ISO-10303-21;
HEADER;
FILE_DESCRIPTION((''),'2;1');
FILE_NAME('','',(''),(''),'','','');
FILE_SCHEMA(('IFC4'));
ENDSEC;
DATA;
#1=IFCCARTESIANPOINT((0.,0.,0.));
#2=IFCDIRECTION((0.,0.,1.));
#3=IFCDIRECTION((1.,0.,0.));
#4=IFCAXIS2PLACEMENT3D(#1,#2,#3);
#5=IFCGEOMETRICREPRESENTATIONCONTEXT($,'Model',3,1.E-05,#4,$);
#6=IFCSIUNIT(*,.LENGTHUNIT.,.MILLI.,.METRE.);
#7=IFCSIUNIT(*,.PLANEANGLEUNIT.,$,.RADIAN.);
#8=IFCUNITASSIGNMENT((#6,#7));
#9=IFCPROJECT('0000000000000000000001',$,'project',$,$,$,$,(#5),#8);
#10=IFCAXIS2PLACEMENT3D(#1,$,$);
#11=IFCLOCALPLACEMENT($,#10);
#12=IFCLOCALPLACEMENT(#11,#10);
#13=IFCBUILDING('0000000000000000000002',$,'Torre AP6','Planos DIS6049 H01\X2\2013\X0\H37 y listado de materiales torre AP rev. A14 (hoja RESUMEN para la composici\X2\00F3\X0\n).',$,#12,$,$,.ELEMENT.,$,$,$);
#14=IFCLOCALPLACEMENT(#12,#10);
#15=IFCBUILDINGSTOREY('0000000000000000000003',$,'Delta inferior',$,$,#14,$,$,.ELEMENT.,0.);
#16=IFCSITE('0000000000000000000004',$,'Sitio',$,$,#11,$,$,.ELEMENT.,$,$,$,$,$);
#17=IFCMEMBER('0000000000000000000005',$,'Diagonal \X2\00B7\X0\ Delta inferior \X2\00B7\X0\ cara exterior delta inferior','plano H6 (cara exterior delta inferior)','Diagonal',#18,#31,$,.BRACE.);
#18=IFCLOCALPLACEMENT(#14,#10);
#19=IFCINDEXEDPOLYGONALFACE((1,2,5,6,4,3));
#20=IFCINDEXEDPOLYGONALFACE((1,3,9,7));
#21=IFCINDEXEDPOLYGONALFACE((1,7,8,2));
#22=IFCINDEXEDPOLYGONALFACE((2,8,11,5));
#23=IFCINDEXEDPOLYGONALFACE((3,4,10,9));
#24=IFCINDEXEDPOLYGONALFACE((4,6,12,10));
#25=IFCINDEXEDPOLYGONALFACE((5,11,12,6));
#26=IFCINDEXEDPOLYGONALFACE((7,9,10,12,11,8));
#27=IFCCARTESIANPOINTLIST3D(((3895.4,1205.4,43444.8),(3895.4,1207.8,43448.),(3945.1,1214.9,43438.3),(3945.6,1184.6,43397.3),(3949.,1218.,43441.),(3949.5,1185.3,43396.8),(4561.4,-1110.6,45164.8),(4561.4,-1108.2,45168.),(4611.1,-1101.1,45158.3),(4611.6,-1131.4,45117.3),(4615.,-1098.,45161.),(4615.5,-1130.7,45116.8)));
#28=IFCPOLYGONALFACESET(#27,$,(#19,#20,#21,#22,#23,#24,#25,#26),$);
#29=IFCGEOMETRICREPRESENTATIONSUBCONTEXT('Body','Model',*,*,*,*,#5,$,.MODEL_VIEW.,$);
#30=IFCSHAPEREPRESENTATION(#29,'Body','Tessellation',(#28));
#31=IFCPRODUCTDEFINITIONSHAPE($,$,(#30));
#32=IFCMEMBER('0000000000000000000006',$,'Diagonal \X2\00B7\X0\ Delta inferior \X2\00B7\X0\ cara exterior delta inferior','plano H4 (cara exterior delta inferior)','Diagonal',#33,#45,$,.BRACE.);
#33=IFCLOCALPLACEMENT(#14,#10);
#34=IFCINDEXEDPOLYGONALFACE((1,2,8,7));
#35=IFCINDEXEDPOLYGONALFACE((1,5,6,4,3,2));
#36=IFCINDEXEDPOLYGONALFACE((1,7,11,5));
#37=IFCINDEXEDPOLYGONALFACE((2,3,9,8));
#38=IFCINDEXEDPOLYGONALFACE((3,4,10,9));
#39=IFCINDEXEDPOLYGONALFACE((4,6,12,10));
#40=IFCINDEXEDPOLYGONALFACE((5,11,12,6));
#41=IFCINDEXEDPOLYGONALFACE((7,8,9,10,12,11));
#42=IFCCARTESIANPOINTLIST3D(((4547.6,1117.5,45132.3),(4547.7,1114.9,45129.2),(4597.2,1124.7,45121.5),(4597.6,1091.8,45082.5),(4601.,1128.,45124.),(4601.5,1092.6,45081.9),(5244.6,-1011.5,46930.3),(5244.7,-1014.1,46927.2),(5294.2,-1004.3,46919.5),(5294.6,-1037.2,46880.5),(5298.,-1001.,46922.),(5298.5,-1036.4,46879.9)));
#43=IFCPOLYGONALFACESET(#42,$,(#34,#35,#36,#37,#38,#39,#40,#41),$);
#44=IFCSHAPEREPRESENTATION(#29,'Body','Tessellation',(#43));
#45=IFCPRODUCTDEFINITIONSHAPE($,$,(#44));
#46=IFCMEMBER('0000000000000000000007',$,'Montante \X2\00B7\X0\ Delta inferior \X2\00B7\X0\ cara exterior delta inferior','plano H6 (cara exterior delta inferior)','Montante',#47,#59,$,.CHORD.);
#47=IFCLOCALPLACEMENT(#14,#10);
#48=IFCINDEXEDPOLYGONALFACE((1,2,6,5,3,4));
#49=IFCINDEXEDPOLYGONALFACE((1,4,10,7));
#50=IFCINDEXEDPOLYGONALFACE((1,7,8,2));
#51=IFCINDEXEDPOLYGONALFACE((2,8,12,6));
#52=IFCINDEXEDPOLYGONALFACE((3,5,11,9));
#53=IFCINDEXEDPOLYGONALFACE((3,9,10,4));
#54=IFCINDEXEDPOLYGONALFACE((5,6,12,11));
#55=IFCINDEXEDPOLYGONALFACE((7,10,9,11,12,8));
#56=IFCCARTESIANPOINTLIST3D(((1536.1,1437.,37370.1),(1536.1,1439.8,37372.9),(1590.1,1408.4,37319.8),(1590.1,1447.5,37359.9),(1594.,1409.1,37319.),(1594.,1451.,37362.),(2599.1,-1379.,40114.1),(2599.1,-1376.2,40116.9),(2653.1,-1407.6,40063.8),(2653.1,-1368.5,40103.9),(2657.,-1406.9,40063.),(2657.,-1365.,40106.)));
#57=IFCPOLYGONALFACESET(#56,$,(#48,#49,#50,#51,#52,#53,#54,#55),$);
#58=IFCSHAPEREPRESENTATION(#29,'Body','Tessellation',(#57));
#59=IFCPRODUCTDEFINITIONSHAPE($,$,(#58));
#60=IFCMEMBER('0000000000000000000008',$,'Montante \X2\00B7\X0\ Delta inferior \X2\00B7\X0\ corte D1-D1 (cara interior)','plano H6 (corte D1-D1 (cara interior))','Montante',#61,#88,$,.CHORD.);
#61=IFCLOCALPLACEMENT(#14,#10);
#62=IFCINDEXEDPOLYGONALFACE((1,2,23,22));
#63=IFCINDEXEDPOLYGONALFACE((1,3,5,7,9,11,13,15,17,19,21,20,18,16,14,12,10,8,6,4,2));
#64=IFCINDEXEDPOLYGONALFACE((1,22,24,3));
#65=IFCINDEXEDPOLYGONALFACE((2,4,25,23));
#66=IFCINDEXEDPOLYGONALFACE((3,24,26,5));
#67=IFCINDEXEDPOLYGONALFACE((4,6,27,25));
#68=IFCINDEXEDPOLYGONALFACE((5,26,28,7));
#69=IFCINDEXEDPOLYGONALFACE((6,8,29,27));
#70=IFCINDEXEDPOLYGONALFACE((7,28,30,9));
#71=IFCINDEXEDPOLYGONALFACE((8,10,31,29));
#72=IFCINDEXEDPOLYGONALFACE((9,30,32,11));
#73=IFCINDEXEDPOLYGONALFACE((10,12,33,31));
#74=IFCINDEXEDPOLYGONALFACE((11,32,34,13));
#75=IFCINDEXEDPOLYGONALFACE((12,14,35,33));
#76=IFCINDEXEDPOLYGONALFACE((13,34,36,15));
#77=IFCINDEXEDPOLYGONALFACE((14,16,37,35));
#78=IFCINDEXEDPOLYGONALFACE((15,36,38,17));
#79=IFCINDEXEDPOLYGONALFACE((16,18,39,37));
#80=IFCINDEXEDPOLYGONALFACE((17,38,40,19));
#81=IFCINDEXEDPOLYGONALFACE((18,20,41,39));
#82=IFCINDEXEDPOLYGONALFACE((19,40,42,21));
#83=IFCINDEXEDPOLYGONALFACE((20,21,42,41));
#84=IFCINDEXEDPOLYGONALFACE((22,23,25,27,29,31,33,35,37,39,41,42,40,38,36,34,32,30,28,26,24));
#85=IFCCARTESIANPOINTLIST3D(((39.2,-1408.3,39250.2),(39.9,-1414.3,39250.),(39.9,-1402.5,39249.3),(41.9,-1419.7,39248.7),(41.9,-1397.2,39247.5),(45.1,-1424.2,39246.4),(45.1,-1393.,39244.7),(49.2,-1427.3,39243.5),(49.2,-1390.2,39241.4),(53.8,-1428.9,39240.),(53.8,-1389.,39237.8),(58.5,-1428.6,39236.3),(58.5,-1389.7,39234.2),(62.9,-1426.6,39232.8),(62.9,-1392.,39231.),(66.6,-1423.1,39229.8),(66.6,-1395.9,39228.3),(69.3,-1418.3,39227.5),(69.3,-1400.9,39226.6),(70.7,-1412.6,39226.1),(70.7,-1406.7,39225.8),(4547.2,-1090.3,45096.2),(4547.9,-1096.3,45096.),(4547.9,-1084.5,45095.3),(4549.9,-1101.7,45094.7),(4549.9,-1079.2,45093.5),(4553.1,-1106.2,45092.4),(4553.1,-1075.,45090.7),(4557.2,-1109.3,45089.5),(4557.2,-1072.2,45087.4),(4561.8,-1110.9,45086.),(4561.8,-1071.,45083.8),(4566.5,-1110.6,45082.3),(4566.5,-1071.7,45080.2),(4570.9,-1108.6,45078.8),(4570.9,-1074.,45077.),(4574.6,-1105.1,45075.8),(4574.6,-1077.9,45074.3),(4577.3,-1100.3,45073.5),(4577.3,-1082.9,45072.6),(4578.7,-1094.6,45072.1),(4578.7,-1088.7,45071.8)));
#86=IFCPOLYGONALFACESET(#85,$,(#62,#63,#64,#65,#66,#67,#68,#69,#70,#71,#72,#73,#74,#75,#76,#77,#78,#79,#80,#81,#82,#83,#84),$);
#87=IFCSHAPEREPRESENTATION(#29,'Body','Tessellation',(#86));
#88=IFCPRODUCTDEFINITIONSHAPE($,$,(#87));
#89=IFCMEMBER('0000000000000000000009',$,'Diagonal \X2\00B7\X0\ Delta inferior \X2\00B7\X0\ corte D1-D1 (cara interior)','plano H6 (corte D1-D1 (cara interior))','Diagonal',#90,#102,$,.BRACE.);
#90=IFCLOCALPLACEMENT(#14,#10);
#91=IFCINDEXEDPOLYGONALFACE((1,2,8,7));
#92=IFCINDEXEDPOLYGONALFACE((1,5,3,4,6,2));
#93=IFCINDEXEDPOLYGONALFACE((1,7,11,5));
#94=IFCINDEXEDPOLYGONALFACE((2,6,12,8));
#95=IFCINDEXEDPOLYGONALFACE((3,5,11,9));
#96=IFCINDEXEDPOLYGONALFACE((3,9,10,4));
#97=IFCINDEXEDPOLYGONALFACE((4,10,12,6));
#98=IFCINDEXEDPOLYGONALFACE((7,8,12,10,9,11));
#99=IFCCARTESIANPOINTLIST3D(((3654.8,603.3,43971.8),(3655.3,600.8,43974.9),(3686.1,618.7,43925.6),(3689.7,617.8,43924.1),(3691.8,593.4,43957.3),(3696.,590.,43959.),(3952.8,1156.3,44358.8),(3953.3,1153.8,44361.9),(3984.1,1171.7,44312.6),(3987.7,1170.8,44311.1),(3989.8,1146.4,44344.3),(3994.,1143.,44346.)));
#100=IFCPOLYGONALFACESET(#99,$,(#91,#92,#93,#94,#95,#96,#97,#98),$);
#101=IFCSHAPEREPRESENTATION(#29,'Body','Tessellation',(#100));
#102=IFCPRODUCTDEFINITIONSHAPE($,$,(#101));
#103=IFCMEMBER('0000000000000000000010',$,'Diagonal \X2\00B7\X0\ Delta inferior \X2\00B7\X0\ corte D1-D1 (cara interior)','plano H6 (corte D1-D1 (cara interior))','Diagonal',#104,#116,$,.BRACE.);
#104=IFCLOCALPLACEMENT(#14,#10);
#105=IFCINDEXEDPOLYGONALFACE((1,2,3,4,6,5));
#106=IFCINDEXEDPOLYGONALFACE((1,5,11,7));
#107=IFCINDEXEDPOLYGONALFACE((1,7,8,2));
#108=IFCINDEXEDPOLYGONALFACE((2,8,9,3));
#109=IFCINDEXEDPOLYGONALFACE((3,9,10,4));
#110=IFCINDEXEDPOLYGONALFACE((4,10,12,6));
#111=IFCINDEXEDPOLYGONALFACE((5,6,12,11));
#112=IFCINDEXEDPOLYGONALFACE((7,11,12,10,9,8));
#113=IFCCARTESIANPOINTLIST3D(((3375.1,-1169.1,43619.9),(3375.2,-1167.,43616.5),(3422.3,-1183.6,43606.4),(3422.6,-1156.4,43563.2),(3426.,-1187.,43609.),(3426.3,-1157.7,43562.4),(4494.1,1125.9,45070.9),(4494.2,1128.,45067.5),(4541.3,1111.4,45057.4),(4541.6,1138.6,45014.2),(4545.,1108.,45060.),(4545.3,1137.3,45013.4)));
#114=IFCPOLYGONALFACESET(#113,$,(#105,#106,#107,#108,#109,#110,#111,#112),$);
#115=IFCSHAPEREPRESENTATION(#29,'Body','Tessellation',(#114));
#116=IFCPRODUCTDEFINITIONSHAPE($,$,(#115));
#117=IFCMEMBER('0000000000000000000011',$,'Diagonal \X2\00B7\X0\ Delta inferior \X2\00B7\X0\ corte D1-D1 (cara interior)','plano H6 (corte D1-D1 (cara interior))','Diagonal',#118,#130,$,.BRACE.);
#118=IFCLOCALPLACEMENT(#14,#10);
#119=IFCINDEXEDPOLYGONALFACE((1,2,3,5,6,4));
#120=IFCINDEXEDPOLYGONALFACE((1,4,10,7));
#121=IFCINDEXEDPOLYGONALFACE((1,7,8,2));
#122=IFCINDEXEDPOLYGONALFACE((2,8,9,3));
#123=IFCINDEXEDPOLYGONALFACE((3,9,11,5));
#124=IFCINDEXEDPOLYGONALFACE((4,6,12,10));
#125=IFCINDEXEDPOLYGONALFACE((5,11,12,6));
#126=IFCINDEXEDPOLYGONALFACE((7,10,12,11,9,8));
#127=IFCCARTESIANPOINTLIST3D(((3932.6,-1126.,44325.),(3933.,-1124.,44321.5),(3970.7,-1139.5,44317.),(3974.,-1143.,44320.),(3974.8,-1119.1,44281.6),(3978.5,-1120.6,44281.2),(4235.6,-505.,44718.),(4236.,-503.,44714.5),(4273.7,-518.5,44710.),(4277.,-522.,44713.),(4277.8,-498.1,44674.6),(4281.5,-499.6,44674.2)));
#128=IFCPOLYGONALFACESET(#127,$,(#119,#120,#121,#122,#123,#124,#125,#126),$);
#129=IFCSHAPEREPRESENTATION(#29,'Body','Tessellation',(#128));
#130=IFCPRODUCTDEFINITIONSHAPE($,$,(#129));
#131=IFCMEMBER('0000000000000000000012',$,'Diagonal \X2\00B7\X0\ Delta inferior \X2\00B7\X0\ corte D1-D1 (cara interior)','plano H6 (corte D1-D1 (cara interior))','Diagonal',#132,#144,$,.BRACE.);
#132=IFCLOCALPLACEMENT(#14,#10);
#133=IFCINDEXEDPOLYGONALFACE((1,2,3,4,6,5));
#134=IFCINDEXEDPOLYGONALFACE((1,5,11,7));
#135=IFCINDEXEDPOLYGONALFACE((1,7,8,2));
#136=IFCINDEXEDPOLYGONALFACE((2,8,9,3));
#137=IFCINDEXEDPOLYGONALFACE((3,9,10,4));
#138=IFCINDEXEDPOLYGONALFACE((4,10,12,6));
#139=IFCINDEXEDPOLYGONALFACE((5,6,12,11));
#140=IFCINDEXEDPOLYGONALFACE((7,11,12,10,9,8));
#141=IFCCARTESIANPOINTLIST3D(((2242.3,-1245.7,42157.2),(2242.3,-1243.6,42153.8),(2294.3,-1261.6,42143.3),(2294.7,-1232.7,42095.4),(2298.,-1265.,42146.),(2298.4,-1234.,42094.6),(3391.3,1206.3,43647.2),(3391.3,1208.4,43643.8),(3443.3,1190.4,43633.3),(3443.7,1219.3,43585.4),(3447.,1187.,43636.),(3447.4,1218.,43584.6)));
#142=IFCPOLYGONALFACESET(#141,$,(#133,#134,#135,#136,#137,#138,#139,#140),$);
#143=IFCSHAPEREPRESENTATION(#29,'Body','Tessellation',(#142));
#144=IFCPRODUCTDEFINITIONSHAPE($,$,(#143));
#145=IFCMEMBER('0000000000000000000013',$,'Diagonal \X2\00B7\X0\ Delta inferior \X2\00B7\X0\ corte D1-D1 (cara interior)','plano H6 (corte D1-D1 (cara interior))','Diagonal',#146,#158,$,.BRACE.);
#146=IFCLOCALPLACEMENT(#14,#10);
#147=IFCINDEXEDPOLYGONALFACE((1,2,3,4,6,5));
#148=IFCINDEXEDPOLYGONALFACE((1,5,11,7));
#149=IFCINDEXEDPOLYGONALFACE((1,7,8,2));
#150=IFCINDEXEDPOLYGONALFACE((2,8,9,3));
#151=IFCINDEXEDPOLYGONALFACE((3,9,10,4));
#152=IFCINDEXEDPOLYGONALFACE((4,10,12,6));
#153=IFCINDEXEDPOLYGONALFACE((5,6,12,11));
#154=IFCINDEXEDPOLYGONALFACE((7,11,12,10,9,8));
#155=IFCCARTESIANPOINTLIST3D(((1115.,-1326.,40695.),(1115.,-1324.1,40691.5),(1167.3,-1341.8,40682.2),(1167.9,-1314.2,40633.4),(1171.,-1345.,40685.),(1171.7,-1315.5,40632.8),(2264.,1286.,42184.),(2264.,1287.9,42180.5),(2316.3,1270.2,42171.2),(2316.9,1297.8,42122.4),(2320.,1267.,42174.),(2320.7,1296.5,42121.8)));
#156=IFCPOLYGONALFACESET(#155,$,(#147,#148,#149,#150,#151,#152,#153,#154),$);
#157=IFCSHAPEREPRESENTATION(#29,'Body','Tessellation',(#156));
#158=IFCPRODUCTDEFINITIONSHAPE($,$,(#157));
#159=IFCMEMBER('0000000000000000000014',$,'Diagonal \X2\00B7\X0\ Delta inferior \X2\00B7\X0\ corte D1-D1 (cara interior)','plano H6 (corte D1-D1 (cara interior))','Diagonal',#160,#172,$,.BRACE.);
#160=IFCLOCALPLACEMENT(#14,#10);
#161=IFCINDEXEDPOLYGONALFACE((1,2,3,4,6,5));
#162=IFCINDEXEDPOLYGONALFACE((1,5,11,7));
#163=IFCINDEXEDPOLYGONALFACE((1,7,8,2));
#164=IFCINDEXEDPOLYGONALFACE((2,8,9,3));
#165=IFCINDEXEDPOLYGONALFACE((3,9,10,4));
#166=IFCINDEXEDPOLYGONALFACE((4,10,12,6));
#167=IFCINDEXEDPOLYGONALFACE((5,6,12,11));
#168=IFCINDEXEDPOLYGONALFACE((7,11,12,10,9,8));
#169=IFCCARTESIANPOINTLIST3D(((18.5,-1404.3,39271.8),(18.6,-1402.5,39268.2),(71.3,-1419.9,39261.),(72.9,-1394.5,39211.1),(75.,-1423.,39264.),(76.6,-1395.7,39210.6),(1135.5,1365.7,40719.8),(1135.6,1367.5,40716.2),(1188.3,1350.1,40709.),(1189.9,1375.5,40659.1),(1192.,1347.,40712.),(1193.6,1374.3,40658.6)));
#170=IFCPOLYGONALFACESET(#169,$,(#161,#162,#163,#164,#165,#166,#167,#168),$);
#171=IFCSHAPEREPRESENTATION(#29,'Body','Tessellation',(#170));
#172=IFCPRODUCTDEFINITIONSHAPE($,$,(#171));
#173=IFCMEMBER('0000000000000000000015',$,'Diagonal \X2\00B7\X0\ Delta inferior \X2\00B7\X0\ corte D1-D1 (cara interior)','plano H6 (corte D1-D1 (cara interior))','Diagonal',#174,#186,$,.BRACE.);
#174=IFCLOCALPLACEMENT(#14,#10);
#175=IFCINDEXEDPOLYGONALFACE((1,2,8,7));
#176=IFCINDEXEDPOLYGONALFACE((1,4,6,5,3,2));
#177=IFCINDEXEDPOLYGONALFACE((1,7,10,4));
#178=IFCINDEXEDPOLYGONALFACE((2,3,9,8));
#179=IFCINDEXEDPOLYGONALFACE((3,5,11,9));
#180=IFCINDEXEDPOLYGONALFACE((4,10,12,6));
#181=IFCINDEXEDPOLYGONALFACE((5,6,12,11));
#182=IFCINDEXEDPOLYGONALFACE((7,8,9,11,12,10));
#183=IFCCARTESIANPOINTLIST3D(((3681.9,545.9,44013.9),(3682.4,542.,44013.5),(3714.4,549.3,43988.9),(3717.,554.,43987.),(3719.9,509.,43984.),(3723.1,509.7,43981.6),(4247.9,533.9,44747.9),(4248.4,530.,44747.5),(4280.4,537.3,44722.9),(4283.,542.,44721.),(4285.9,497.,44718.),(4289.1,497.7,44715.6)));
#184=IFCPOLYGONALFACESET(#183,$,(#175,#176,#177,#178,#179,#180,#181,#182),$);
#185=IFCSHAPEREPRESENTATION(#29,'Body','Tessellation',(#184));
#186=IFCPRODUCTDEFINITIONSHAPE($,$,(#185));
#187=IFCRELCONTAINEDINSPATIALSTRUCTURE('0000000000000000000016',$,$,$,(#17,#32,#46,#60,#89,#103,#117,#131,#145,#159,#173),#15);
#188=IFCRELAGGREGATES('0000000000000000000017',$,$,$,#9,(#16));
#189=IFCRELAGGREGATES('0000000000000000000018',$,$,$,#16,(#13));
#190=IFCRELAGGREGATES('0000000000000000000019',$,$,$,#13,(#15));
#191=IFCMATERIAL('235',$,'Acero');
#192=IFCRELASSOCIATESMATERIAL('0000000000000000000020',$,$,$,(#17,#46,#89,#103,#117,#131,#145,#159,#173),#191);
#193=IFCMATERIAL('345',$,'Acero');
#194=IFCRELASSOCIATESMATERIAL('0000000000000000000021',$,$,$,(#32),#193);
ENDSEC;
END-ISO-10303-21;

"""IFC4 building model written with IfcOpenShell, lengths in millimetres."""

from ifc_helpers import new_model, si_unit, frame, frame_2d, origin, origin_with_axes, place, context, subcontext, project, spatial, circle, l_section, extrude, material, element, save


model = new_model("IFC4")

# Units and contexts
model_context = context("Model", 3, precision=1e-05, world=origin_with_axes())
body_context = subcontext(model_context, "Body", "Model", "MODEL_VIEW")
ifc_project = project(units=[si_unit("LENGTHUNIT", "METRE", prefix="MILLI"), si_unit("PLANEANGLEUNIT", "RADIAN")], contexts=[model_context])

# Site, building, storey
site_placement = place(None, origin())
site = spatial("IfcSite", under=ifc_project, at=site_placement, Name="Sitio", CompositionType="ELEMENT")
building_placement = place(site_placement, origin())
building = spatial("IfcBuilding", under=site, at=building_placement, Name="Torre AP6", Description="Planos DIS6049 H01–H37 y listado de materiales torre AP rev. A14 (hoja RESUMEN para la composición).", CompositionType="ELEMENT")
storey_placement = place(building_placement, origin())
storey = spatial("IfcBuildingStorey", under=building, at=storey_placement, Name="Delta inferior", CompositionType="ELEMENT", Elevation=0.0)

# Members
ifc_material_1 = material(Name="235", Category="Acero")
ifc_material_2 = material(Name="345", Category="Acero")
member_1_placement = place(storey_placement, frame((3949.0, 1218.0, 43441.0), z_axis=(0.224946, -0.782244, 0.580941), x_axis=(-0.974336, -0.185683, 0.127247)))
element("IfcMember", 1, at=member_1_placement, inside=storey, material=ifc_material_1, Name="Diagonal · Delta inferior · cara exterior delta inferior", Description="plano H6 (cara exterior delta inferior)", ObjectType="Diagonal", PredefinedType="BRACE", context=body_context, shape_type="SweptSolid", body=[
    extrude(l_section(Depth=55.0, Width=55.0, Thickness=4.0, at=frame_2d((27.5, 27.5))), None, (0.0, 0.0, 1.0), 2960.7),
])
member_2_placement = place(storey_placement, frame((4601.0, 1128.0, 45124.0), z_axis=(0.242646, -0.741166, 0.625936), x_axis=(-0.97008, -0.190866, 0.150051)))
element("IfcMember", 2, at=member_2_placement, inside=storey, material=ifc_material_2, Name="Diagonal · Delta inferior · cara exterior delta inferior", Description="plano H4 (cara exterior delta inferior)", ObjectType="Diagonal", PredefinedType="BRACE", context=body_context, shape_type="SweptSolid", body=[
    extrude(l_section(Depth=55.0, Width=55.0, Thickness=4.0, at=frame_2d((27.5, 27.5))), None, (0.0, 0.0, 1.0), 2872.5),
])
member_3_placement = place(storey_placement, frame((1594.0, 1451.0, 37362.0), z_axis=(0.260987, -0.691382, 0.673704), x_axis=(-0.965342, -0.18692, 0.18214)))
element("IfcMember", 3, at=member_3_placement, inside=storey, material=ifc_material_1, Name="Montante · Delta inferior · cara exterior delta inferior", Description="plano H6 (cara exterior delta inferior)", ObjectType="Montante", PredefinedType="CHORD", context=body_context, shape_type="SweptSolid", body=[
    extrude(l_section(Depth=60.0, Width=60.0, Thickness=4.0, at=frame_2d((30.0, 30.0))), None, (0.0, 0.0, 1.0), 4073.0),
])
member_4_placement = place(storey_placement, frame((4563.0, -1091.0, 45084.0), z_axis=(-0.610087, -0.043036, -0.791165), x_axis=(-0.792334, 0.033137, 0.609187)))
element("IfcMember", 4, at=member_4_placement, inside=storey, Name="Montante · Delta inferior · corte D1-D1 (cara interior)", Description="plano H6 (corte D1-D1 (cara interior))", ObjectType="Montante", PredefinedType="CHORD", context=body_context, shape_type="SweptSolid", body=[
    extrude(circle(Radius=20.0), None, (0.0, 0.0, 1.0), 7389.1),
])
member_5_placement = place(storey_placement, frame((3994.0, 1143.0, 44346.0), z_axis=(-0.403891, -0.749503, -0.524516), x_axis=(-0.904178, 0.239916, 0.353414)))
element("IfcMember", 5, at=member_5_placement, inside=storey, material=ifc_material_1, Name="Diagonal · Delta inferior · corte D1-D1 (cara interior)", Description="plano H6 (corte D1-D1 (cara interior))", ObjectType="Diagonal", PredefinedType="BRACE", context=body_context, shape_type="SweptSolid", body=[
    extrude(l_section(Depth=45.0, Width=45.0, Thickness=4.0, at=frame_2d((22.5, 22.5))), None, (0.0, 0.0, 1.0), 737.8),
])
member_6_placement = place(storey_placement, frame((4545.0, 1108.0, 45060.0), z_axis=(-0.381032, -0.781472, -0.494081), x_axis=(-0.924547, 0.325107, 0.198793)))
element("IfcMember", 6, at=member_6_placement, inside=storey, material=ifc_material_1, Name="Diagonal · Delta inferior · corte D1-D1 (cara interior)", Description="plano H6 (corte D1-D1 (cara interior))", ObjectType="Diagonal", PredefinedType="BRACE", context=body_context, shape_type="SweptSolid", body=[
    extrude(l_section(Depth=55.0, Width=55.0, Thickness=4.0, at=frame_2d((27.5, 27.5))), None, (0.0, 0.0, 1.0), 2936.8),
])
member_7_placement = place(storey_placement, frame((4277.0, -522.0, 44713.0), z_axis=(-0.38117, -0.78121, -0.494389), x_axis=(-0.919056, 0.378167, 0.111023)))
element("IfcMember", 7, at=member_7_placement, inside=storey, material=ifc_material_1, Name="Diagonal · Delta inferior · corte D1-D1 (cara interior)", Description="plano H6 (corte D1-D1 (cara interior))", ObjectType="Diagonal", PredefinedType="BRACE", context=body_context, shape_type="SweptSolid", body=[
    extrude(l_section(Depth=45.0, Width=45.0, Thickness=4.0, at=frame_2d((22.5, 22.5))), None, (0.0, 0.0, 1.0), 794.9),
])
member_8_placement = place(storey_placement, frame((3447.0, 1187.0, 43636.0), z_axis=(-0.371757, -0.79334, -0.482087), x_axis=(-0.928304, 0.321616, 0.18659)))
element("IfcMember", 8, at=member_8_placement, inside=storey, material=ifc_material_1, Name="Diagonal · Delta inferior · corte D1-D1 (cara interior)", Description="plano H6 (corte D1-D1 (cara interior))", ObjectType="Diagonal", PredefinedType="BRACE", context=body_context, shape_type="SweptSolid", body=[
    extrude(l_section(Depth=60.0, Width=60.0, Thickness=4.0, at=frame_2d((30.0, 30.0))), None, (0.0, 0.0, 1.0), 3090.7),
])
member_9_placement = place(storey_placement, frame((2320.0, 1267.0, 42174.0), z_axis=(-0.356979, -0.811514, -0.462613), x_axis=(-0.934048, 0.315929, 0.166565)))
element("IfcMember", 9, at=member_9_placement, inside=storey, material=ifc_material_1, Name="Diagonal · Delta inferior · corte D1-D1 (cara interior)", Description="plano H6 (corte D1-D1 (cara interior))", ObjectType="Diagonal", PredefinedType="BRACE", context=body_context, shape_type="SweptSolid", body=[
    extrude(l_section(Depth=60.0, Width=60.0, Thickness=4.0, at=frame_2d((30.0, 30.0))), None, (0.0, 0.0, 1.0), 3218.7),
])
member_10_placement = place(storey_placement, frame((1192.0, 1347.0, 40712.0), z_axis=(-0.336524, -0.834531, -0.436246), x_axis=(-0.94128, 0.311519, 0.130181)))
element("IfcMember", 10, at=member_10_placement, inside=storey, material=ifc_material_1, Name="Diagonal · Delta inferior · corte D1-D1 (cara interior)", Description="plano H6 (corte D1-D1 (cara interior))", ObjectType="Diagonal", PredefinedType="BRACE", context=body_context, shape_type="SweptSolid", body=[
    extrude(l_section(Depth=60.0, Width=60.0, Thickness=4.0, at=frame_2d((30.0, 30.0))), None, (0.0, 0.0, 1.0), 3319.2),
])
member_11_placement = place(storey_placement, frame((3717.0, 554.0, 43987.0), z_axis=(0.610598, -0.012946, 0.791835), x_axis=(-0.780393, -0.179966, 0.598832)))
element("IfcMember", 11, at=member_11_placement, inside=storey, material=ifc_material_1, Name="Diagonal · Delta inferior · corte D1-D1 (cara interior)", Description="plano H6 (corte D1-D1 (cara interior))", ObjectType="Diagonal", PredefinedType="BRACE", context=body_context, shape_type="SweptSolid", body=[
    extrude(l_section(Depth=45.0, Width=45.0, Thickness=4.0, at=frame_2d((22.5, 22.5))), None, (0.0, 0.0, 1.0), 927.0),
])

save(model, "model.ifc")
